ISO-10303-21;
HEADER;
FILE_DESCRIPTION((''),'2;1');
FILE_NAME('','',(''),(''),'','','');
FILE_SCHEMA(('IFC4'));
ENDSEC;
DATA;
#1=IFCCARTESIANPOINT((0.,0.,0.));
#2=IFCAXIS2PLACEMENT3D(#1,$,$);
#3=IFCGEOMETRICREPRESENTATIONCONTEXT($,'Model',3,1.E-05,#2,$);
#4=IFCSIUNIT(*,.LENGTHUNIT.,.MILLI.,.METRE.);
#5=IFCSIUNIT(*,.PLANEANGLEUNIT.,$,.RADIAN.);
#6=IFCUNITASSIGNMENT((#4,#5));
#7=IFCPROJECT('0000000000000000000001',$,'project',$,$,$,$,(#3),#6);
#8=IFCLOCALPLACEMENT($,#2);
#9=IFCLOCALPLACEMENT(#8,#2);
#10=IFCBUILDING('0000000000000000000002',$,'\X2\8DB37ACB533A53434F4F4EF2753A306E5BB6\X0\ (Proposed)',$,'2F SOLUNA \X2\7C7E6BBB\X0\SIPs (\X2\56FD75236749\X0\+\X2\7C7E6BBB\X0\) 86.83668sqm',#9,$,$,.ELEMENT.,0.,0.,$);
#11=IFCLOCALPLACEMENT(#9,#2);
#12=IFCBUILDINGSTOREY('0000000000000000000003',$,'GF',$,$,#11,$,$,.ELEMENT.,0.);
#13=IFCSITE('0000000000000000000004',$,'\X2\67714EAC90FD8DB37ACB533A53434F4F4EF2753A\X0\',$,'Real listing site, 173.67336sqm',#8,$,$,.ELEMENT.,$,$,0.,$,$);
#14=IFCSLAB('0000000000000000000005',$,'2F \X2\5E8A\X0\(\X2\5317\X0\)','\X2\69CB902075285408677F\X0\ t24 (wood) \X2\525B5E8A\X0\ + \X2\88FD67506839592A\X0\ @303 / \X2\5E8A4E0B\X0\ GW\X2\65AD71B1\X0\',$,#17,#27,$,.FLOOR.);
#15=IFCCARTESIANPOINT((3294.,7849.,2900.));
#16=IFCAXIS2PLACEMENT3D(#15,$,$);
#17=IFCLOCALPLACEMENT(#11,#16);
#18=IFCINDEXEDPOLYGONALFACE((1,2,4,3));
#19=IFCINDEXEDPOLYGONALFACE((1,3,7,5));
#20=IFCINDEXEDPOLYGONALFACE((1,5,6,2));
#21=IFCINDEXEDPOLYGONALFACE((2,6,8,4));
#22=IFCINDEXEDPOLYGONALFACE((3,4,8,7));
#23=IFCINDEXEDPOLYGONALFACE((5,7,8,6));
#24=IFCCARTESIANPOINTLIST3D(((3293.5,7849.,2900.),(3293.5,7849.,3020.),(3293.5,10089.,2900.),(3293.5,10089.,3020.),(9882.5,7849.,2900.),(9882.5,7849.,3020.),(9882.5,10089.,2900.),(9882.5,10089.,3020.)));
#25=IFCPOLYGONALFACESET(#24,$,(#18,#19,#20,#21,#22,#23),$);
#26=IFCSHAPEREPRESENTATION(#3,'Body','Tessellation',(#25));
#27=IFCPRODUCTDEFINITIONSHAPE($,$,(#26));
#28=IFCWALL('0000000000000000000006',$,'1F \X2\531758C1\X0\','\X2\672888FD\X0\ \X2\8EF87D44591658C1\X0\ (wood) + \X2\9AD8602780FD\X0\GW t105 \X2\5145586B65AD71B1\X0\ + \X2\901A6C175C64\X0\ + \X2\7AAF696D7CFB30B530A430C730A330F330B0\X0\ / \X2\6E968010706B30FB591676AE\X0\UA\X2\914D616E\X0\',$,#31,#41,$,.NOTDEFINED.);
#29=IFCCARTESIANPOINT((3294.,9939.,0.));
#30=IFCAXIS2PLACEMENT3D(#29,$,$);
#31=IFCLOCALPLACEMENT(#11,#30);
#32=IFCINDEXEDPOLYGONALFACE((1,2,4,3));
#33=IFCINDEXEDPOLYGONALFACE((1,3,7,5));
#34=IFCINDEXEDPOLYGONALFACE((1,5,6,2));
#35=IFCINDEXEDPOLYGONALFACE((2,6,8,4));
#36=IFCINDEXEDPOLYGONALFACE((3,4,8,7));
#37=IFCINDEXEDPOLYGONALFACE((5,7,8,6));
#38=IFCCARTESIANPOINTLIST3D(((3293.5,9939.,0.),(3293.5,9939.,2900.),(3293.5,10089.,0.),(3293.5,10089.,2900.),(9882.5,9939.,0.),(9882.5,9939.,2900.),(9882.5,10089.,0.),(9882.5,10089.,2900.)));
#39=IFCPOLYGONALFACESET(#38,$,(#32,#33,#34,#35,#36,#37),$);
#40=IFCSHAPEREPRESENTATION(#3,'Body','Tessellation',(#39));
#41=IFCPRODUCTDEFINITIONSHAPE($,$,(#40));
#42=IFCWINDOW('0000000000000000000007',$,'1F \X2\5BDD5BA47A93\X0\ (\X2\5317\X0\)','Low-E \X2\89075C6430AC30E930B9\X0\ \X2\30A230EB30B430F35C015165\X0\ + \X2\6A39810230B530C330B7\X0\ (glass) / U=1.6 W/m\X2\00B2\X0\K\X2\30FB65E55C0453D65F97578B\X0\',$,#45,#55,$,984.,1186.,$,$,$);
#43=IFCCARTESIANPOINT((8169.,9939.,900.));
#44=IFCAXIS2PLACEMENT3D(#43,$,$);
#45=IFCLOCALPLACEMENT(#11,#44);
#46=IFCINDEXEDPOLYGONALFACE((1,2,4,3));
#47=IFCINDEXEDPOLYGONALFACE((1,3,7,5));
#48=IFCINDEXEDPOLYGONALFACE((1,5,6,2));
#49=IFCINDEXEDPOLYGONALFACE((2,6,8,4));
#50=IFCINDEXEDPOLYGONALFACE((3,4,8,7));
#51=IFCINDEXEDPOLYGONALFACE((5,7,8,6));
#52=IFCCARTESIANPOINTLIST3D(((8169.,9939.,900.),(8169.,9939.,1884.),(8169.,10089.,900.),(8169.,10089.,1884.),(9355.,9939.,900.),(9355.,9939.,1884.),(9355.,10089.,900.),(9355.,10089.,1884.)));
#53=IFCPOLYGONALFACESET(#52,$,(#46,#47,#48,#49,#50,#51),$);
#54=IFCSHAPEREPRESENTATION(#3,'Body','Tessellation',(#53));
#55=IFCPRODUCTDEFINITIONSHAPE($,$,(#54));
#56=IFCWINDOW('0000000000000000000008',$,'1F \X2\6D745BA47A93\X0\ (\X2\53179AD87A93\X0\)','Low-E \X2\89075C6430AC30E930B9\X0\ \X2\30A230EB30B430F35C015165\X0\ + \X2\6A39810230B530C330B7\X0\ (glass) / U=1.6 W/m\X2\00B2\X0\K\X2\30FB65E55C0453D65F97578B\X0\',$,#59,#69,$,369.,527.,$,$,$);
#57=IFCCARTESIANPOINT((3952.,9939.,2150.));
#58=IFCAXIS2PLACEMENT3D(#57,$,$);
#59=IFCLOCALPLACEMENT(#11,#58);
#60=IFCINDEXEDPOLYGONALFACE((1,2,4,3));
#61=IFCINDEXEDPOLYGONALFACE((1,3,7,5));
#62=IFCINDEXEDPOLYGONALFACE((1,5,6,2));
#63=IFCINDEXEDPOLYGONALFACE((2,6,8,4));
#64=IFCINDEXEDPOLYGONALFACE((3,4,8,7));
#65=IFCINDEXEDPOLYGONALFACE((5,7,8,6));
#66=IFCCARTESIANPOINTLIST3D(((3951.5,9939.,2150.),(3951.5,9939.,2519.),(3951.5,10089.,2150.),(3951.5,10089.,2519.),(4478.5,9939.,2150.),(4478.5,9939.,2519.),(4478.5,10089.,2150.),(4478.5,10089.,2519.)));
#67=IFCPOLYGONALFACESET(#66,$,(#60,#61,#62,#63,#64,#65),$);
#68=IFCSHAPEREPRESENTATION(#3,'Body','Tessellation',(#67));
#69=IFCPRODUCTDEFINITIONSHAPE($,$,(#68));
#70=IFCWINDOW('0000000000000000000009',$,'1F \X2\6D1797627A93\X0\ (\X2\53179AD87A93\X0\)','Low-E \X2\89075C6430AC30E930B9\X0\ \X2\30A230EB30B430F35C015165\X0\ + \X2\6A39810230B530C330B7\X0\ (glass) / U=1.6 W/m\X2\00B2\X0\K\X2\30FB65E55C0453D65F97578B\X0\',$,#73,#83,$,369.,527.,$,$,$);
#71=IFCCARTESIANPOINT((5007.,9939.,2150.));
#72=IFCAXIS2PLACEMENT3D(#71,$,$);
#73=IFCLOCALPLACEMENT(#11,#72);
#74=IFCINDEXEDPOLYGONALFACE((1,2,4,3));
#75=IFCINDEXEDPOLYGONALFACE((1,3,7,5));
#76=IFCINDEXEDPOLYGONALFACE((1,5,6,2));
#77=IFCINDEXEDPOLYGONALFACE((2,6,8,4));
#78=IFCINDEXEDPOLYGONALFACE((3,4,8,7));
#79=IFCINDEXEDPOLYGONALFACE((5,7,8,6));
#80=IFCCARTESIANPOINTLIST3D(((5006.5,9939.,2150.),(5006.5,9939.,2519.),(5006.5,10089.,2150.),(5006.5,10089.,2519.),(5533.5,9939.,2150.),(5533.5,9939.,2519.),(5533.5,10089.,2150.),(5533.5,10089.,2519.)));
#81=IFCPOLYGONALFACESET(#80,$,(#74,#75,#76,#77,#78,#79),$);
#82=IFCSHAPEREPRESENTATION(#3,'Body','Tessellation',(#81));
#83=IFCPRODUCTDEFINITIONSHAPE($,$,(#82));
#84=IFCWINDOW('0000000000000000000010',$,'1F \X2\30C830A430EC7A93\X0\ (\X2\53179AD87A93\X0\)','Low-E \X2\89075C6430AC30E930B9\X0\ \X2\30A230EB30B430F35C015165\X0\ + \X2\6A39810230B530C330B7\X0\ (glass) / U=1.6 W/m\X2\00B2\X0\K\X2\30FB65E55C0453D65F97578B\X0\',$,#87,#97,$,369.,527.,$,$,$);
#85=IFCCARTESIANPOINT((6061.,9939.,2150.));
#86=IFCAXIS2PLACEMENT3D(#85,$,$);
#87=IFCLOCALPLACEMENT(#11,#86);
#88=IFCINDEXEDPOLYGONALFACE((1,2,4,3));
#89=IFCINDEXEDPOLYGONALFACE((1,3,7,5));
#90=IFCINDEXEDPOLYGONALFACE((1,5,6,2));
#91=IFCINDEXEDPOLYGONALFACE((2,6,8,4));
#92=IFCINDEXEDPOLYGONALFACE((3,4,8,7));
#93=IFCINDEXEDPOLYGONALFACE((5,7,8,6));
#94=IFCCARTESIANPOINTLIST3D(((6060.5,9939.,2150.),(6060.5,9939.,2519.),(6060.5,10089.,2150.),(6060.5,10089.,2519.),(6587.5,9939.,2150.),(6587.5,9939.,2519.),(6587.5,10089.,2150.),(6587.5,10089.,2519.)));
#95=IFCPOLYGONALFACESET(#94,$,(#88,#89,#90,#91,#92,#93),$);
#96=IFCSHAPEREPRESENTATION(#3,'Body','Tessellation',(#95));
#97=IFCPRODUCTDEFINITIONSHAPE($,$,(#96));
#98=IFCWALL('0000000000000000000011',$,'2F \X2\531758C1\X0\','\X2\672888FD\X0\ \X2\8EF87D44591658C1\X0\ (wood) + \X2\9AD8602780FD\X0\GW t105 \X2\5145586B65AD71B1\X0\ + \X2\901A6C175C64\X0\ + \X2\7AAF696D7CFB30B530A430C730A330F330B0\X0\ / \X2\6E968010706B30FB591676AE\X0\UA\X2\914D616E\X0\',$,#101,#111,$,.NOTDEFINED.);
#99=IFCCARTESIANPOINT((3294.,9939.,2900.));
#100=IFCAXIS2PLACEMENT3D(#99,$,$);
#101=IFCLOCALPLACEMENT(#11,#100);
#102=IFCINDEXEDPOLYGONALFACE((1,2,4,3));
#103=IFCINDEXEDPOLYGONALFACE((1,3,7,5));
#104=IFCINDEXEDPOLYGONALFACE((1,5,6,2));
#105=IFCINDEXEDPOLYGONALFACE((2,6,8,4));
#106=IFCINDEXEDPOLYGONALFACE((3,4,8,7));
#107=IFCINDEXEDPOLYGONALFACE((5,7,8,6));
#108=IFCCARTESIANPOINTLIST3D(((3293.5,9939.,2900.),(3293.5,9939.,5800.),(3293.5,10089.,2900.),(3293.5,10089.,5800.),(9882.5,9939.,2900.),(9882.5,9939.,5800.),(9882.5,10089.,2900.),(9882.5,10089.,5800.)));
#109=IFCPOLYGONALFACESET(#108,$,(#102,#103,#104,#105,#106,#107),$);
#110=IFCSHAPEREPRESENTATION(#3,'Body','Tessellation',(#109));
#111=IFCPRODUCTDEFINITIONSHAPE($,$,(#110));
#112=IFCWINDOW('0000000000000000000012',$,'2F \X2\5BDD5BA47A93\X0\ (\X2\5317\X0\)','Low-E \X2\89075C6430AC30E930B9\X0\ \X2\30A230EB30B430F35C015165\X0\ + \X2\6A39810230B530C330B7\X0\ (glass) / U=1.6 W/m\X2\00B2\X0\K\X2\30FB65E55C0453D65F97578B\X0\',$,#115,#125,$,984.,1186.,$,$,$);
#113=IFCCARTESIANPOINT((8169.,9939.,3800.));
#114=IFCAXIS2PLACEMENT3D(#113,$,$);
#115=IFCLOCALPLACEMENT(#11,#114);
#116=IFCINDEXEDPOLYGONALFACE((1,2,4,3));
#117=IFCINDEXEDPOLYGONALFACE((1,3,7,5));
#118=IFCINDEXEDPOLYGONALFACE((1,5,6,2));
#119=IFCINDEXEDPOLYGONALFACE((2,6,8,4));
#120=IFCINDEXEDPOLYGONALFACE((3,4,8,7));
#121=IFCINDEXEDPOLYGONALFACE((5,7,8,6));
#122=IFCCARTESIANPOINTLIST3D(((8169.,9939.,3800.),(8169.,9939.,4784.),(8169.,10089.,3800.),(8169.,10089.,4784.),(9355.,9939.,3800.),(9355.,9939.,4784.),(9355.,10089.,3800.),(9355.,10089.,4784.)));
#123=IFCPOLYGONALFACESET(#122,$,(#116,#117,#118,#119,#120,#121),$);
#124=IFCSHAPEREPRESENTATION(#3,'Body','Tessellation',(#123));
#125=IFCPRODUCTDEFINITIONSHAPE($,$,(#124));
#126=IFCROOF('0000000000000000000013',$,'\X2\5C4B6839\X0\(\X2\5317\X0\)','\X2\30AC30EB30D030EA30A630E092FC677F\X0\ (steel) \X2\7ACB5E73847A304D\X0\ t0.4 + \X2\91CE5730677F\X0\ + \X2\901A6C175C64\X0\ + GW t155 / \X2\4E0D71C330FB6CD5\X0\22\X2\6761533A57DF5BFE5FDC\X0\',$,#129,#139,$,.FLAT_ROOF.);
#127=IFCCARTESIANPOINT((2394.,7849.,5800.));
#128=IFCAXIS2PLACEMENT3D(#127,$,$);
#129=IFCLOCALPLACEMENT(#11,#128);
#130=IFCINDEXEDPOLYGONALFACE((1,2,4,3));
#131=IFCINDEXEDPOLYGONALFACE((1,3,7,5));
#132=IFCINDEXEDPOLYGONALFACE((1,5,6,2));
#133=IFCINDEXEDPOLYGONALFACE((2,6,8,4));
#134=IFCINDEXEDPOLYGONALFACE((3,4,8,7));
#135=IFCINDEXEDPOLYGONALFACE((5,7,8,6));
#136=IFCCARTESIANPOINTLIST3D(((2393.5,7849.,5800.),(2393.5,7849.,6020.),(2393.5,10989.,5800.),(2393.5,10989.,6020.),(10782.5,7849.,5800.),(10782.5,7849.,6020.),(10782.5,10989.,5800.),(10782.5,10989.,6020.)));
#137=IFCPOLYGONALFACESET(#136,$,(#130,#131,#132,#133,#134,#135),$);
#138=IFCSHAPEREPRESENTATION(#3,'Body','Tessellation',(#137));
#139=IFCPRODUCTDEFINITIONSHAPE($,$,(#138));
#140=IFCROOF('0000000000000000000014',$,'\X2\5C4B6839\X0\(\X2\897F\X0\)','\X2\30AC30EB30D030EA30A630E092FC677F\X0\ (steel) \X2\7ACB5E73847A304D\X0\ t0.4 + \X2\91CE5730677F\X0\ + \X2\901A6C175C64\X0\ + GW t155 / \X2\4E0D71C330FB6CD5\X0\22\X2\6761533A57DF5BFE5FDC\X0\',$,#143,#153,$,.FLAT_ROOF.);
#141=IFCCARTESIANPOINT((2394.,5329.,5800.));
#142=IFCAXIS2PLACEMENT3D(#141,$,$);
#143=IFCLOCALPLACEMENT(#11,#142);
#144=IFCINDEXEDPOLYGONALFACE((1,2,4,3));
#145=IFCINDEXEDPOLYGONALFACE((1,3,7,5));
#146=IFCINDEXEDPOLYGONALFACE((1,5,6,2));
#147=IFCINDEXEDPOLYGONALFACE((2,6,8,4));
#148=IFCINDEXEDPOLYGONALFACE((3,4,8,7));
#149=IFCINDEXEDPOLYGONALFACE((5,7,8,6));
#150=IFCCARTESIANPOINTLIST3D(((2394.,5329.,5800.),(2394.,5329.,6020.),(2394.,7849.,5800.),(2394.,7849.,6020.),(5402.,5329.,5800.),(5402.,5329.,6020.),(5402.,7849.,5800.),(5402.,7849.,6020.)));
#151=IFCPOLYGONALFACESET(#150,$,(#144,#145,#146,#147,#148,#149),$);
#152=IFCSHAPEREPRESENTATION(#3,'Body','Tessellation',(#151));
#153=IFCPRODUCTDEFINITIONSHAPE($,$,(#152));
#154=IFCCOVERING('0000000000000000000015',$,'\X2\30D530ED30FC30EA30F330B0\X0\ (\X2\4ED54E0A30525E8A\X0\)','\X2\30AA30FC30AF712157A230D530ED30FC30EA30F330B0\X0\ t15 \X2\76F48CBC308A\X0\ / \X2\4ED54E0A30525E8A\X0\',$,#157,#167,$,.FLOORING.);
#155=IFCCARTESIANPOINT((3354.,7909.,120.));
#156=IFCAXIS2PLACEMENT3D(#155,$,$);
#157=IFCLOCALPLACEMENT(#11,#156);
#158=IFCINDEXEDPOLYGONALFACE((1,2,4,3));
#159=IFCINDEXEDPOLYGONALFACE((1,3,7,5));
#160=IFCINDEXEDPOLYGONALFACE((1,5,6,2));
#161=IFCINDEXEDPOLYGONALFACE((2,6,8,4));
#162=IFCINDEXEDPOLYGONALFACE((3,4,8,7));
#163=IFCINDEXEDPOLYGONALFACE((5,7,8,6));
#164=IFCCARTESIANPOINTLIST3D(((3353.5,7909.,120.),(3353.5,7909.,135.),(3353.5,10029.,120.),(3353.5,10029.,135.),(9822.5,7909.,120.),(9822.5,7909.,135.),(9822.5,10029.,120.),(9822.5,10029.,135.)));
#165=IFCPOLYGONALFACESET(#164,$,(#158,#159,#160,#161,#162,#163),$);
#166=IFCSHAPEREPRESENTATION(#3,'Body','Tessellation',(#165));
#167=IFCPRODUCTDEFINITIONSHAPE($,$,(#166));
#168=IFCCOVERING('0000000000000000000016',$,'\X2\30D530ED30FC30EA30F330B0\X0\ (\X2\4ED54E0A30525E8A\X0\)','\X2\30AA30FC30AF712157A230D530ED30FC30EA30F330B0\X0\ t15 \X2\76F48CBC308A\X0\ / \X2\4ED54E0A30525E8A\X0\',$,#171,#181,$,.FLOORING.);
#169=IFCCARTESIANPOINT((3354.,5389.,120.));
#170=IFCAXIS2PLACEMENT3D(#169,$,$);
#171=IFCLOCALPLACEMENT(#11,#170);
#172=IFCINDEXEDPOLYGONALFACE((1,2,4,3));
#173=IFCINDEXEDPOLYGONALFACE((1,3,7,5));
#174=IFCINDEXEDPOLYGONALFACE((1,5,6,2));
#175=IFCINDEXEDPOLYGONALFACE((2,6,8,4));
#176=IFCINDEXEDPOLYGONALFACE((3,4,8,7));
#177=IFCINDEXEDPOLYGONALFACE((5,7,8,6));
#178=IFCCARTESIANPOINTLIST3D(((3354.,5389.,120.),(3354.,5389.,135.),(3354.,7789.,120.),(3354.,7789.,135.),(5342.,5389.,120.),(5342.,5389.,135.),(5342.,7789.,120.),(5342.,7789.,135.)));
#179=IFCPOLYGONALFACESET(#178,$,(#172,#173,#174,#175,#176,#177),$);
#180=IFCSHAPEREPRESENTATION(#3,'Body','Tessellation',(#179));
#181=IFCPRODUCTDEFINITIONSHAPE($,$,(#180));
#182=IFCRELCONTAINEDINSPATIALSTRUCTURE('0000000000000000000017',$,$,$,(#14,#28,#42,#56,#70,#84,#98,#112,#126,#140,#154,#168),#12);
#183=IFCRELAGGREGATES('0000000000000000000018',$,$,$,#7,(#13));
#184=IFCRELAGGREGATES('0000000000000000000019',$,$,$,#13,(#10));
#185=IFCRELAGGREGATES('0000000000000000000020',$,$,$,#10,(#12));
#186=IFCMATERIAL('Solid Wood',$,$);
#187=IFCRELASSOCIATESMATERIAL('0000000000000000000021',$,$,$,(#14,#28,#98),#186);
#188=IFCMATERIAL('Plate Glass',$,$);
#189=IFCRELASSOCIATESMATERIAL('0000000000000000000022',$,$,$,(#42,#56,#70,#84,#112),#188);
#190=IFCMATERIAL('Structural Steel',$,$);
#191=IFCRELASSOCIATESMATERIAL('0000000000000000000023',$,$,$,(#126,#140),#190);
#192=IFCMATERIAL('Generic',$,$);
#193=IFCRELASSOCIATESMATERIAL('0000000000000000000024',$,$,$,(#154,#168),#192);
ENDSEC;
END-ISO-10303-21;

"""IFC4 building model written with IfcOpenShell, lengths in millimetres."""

from ifc_helpers import new_model, si_unit, frame, frame_2d, origin, place, context, project, spatial, rectangle, extrude, material, element, fill, save


model = new_model("IFC4")

# Units and contexts
model_context = context("Model", 3, precision=1e-05, world=origin())
ifc_project = project(units=[si_unit("LENGTHUNIT", "METRE", prefix="MILLI"), si_unit("PLANEANGLEUNIT", "RADIAN")], contexts=[model_context])

# Site, building, storey
site_placement = place(None, origin())
site = spatial("IfcSite", under=ifc_project, at=site_placement, Name="東京都足立区千住仲町", ObjectType="Real listing site, 173.67336sqm", CompositionType="ELEMENT", RefElevation=0.0)
building_placement = place(site_placement, origin())
building = spatial("IfcBuilding", under=site, at=building_placement, Name="足立区千住仲町の家 (Proposed)", ObjectType="2F SOLUNA 籾殻SIPs (国産杉+籾殻) 86.83668sqm", CompositionType="ELEMENT", ElevationOfRefHeight=0.0, ElevationOfTerrain=0.0)
storey_placement = place(building_placement, origin())
storey = spatial("IfcBuildingStorey", under=building, at=storey_placement, Name="GF", CompositionType="ELEMENT", Elevation=0.0)

# Slab
ifc_material_1 = material(Name="Solid Wood")
slab_1_placement = place(storey_placement, frame((3294.0, 7849.0, 2900.0)))
element("IfcSlab", 1, at=slab_1_placement, inside=storey, material=ifc_material_1, Name="2F 床(北)", Description="構造用合板 t24 (wood) 剛床 + 製材根太 @303 / 床下 GW断熱", PredefinedType="FLOOR", context=model_context, shape_type="SweptSolid", body=[
    extrude(rectangle(XDim=6589.0, YDim=2240.0, at=frame_2d((3294.0, 1120.0))), frame((3294.0, 7849.0, 2900.0)), (0.0, 0.0, 1.0), 120.0),
])

# Wall, openings, windows
wall_1_placement = place(storey_placement, frame((3294.0, 9939.0, 0.0)))
wall_1 = element("IfcWall", 2, at=wall_1_placement, inside=storey, material=ifc_material_1, Name="1F 北壁", Description="木製 軸組外壁 (wood) + 高性能GW t105 充填断熱 + 通気層 + 窯業系サイディング / 準耐火・外皮UA配慮", PredefinedType="NOTDEFINED", context=model_context, shape_type="SweptSolid", body=[
    extrude(rectangle(XDim=6589.0, YDim=150.0, at=frame_2d((3294.0, 75.0))), frame((3294.0, 9939.0, 0.0)), (0.0, 0.0, 1.0), 2900.0),
])
opening_1_placement = place(storey_placement, frame((8169.0, 9939.0, 900.0)))
opening_1 = element("IfcOpeningElement", 3, at=opening_1_placement, cuts=wall_1, PredefinedType="NOTDEFINED", context=model_context, shape_type="SweptSolid", body=[
    extrude(rectangle(XDim=1186.0, YDim=150.0, at=frame_2d((593.0, 75.0))), frame((8169.0, 9939.0, 900.0)), (0.0, 0.0, 1.0), 984.0),
])
opening_2_placement = place(storey_placement, frame((3952.0, 9939.0, 2150.0)))
opening_2 = element("IfcOpeningElement", 4, at=opening_2_placement, cuts=wall_1, PredefinedType="NOTDEFINED", context=model_context, shape_type="SweptSolid", body=[
    extrude(rectangle(XDim=527.0, YDim=150.0, at=frame_2d((263.0, 75.0))), frame((3952.0, 9939.0, 2150.0)), (0.0, 0.0, 1.0), 369.0),
])
opening_3_placement = place(storey_placement, frame((5007.0, 9939.0, 2150.0)))
opening_3 = element("IfcOpeningElement", 5, at=opening_3_placement, cuts=wall_1, PredefinedType="NOTDEFINED", context=model_context, shape_type="SweptSolid", body=[
    extrude(rectangle(XDim=527.0, YDim=150.0, at=frame_2d((263.0, 75.0))), frame((5007.0, 9939.0, 2150.0)), (0.0, 0.0, 1.0), 369.0),
])
opening_4_placement = place(storey_placement, frame((6061.0, 9939.0, 2150.0)))
opening_4 = element("IfcOpeningElement", 6, at=opening_4_placement, cuts=wall_1, PredefinedType="NOTDEFINED", context=model_context, shape_type="SweptSolid", body=[
    extrude(rectangle(XDim=527.0, YDim=150.0, at=frame_2d((263.0, 75.0))), frame((6061.0, 9939.0, 2150.0)), (0.0, 0.0, 1.0), 369.0),
])
ifc_material_2 = material(Name="Plate Glass")
window_1_placement = place(storey_placement, frame((8169.0, 9939.0, 900.0)))
window_1 = element("IfcWindow", 7, at=window_1_placement, inside=storey, material=ifc_material_2, Name="1F 寝室窓 (北)", Description="Low-E 複層ガラス アルゴン封入 + 樹脂サッシ (glass) / U=1.6 W/m²K・日射取得型", OverallHeight=984.0, OverallWidth=1186.0, context=model_context, shape_type="SweptSolid", body=[
    extrude(rectangle(XDim=1186.0, YDim=150.0, at=frame_2d((593.0, 75.0))), frame((8169.0, 9939.0, 900.0)), (0.0, 0.0, 1.0), 984.0),
])
fill(opening_1, window_1)
window_2_placement = place(storey_placement, frame((3952.0, 9939.0, 2150.0)))
window_2 = element("IfcWindow", 8, at=window_2_placement, inside=storey, material=ifc_material_2, Name="1F 浴室窓 (北高窓)", Description="Low-E 複層ガラス アルゴン封入 + 樹脂サッシ (glass) / U=1.6 W/m²K・日射取得型", OverallHeight=369.0, OverallWidth=527.0, context=model_context, shape_type="SweptSolid", body=[
    extrude(rectangle(XDim=527.0, YDim=150.0, at=frame_2d((263.0, 75.0))), frame((3952.0, 9939.0, 2150.0)), (0.0, 0.0, 1.0), 369.0),
])
fill(opening_2, window_2)
window_3_placement = place(storey_placement, frame((5007.0, 9939.0, 2150.0)))
window_3 = element("IfcWindow", 9, at=window_3_placement, inside=storey, material=ifc_material_2, Name="1F 洗面窓 (北高窓)", Description="Low-E 複層ガラス アルゴン封入 + 樹脂サッシ (glass) / U=1.6 W/m²K・日射取得型", OverallHeight=369.0, OverallWidth=527.0, context=model_context, shape_type="SweptSolid", body=[
    extrude(rectangle(XDim=527.0, YDim=150.0, at=frame_2d((263.0, 75.0))), frame((5007.0, 9939.0, 2150.0)), (0.0, 0.0, 1.0), 369.0),
])
fill(opening_3, window_3)
window_4_placement = place(storey_placement, frame((6061.0, 9939.0, 2150.0)))
window_4 = element("IfcWindow", 10, at=window_4_placement, inside=storey, material=ifc_material_2, Name="1F トイレ窓 (北高窓)", Description="Low-E 複層ガラス アルゴン封入 + 樹脂サッシ (glass) / U=1.6 W/m²K・日射取得型", OverallHeight=369.0, OverallWidth=527.0, context=model_context, shape_type="SweptSolid", body=[
    extrude(rectangle(XDim=527.0, YDim=150.0, at=frame_2d((263.0, 75.0))), frame((6061.0, 9939.0, 2150.0)), (0.0, 0.0, 1.0), 369.0),
])
fill(opening_4, window_4)

# Wall, opening, window
wall_2_placement = place(storey_placement, frame((3294.0, 9939.0, 2900.0)))
wall_2 = element("IfcWall", 11, at=wall_2_placement, inside=storey, material=ifc_material_1, Name="2F 北壁", Description="木製 軸組外壁 (wood) + 高性能GW t105 充填断熱 + 通気層 + 窯業系サイディング / 準耐火・外皮UA配慮", PredefinedType="NOTDEFINED", context=model_context, shape_type="SweptSolid", body=[
    extrude(rectangle(XDim=6589.0, YDim=150.0, at=frame_2d((3294.0, 75.0))), frame((3294.0, 9939.0, 2900.0)), (0.0, 0.0, 1.0), 2900.0),
])
opening_5_placement = place(storey_placement, frame((8169.0, 9939.0, 3800.0)))
opening_5 = element("IfcOpeningElement", 12, at=opening_5_placement, cuts=wall_2, PredefinedType="NOTDEFINED", context=model_context, shape_type="SweptSolid", body=[
    extrude(rectangle(XDim=1186.0, YDim=150.0, at=frame_2d((593.0, 75.0))), frame((8169.0, 9939.0, 3800.0)), (0.0, 0.0, 1.0), 984.0),
])
window_5_placement = place(storey_placement, frame((8169.0, 9939.0, 3800.0)))
window_5 = element("IfcWindow", 13, at=window_5_placement, inside=storey, material=ifc_material_2, Name="2F 寝室窓 (北)", Description="Low-E 複層ガラス アルゴン封入 + 樹脂サッシ (glass) / U=1.6 W/m²K・日射取得型", OverallHeight=984.0, OverallWidth=1186.0, context=model_context, shape_type="SweptSolid", body=[
    extrude(rectangle(XDim=1186.0, YDim=150.0, at=frame_2d((593.0, 75.0))), frame((8169.0, 9939.0, 3800.0)), (0.0, 0.0, 1.0), 984.0),
])
fill(opening_5, window_5)

# Roofs
ifc_material_3 = material(Name="Structural Steel")
for number, where, name in (
    (14, (2394.0, 7849.0, 5800.0), "屋根(北)"),
):
    element("IfcRoof", number, at=place(storey_placement, frame(where)), inside=storey, material=ifc_material_3, Name=name, Description="ガルバリウム鋼板 (steel) 立平葺き t0.4 + 野地板 + 通気層 + GW t155 / 不燃・法22条区域対応", PredefinedType="FLAT_ROOF", context=model_context, shape_type="SweptSolid", body=[
        extrude(rectangle(XDim=8389.0, YDim=3140.0, at=frame_2d((4194.0, 1570.0))), frame((2394.0, 7849.0, 5800.0)), (0.0, 0.0, 1.0), 220.0),
    ])
roof_placement = place(storey_placement, frame((2394.0, 5329.0, 5800.0)))
element("IfcRoof", 15, at=roof_placement, inside=storey, material=ifc_material_3, Name="屋根(西)", Description="ガルバリウム鋼板 (steel) 立平葺き t0.4 + 野地板 + 通気層 + GW t155 / 不燃・法22条区域対応", PredefinedType="FLAT_ROOF", context=model_context, shape_type="SweptSolid", body=[
    extrude(rectangle(XDim=3008.0, YDim=2520.0, at=frame_2d((1504.0, 1260.0))), frame((2394.0, 5329.0, 5800.0)), (0.0, 0.0, 1.0), 220.0),
])

# Coverings
ifc_material_4 = material(Name="Generic")
covering_1_placement = place(storey_placement, frame((3354.0, 7909.0, 120.0)))
element("IfcCovering", 16, at=covering_1_placement, inside=storey, material=ifc_material_4, Name="フローリング (仕上げ床)", Description="オーク無垢フローリング t15 直貼り / 仕上げ床", PredefinedType="FLOORING", context=model_context, shape_type="SweptSolid", body=[
    extrude(rectangle(XDim=6469.0, YDim=2120.0, at=frame_2d((3234.0, 1060.0))), frame((3354.0, 7909.0, 120.0)), (0.0, 0.0, 1.0), 15.0),
])
covering_2_placement = place(storey_placement, frame((3354.0, 5389.0, 120.0)))
element("IfcCovering", 17, at=covering_2_placement, inside=storey, material=ifc_material_4, Name="フローリング (仕上げ床)", Description="オーク無垢フローリング t15 直貼り / 仕上げ床", PredefinedType="FLOORING", context=model_context, shape_type="SweptSolid", body=[
    extrude(rectangle(XDim=1988.0, YDim=2400.0, at=frame_2d((994.0, 1200.0))), frame((3354.0, 5389.0, 120.0)), (0.0, 0.0, 1.0), 15.0),
])

save(model, "model.ifc")
